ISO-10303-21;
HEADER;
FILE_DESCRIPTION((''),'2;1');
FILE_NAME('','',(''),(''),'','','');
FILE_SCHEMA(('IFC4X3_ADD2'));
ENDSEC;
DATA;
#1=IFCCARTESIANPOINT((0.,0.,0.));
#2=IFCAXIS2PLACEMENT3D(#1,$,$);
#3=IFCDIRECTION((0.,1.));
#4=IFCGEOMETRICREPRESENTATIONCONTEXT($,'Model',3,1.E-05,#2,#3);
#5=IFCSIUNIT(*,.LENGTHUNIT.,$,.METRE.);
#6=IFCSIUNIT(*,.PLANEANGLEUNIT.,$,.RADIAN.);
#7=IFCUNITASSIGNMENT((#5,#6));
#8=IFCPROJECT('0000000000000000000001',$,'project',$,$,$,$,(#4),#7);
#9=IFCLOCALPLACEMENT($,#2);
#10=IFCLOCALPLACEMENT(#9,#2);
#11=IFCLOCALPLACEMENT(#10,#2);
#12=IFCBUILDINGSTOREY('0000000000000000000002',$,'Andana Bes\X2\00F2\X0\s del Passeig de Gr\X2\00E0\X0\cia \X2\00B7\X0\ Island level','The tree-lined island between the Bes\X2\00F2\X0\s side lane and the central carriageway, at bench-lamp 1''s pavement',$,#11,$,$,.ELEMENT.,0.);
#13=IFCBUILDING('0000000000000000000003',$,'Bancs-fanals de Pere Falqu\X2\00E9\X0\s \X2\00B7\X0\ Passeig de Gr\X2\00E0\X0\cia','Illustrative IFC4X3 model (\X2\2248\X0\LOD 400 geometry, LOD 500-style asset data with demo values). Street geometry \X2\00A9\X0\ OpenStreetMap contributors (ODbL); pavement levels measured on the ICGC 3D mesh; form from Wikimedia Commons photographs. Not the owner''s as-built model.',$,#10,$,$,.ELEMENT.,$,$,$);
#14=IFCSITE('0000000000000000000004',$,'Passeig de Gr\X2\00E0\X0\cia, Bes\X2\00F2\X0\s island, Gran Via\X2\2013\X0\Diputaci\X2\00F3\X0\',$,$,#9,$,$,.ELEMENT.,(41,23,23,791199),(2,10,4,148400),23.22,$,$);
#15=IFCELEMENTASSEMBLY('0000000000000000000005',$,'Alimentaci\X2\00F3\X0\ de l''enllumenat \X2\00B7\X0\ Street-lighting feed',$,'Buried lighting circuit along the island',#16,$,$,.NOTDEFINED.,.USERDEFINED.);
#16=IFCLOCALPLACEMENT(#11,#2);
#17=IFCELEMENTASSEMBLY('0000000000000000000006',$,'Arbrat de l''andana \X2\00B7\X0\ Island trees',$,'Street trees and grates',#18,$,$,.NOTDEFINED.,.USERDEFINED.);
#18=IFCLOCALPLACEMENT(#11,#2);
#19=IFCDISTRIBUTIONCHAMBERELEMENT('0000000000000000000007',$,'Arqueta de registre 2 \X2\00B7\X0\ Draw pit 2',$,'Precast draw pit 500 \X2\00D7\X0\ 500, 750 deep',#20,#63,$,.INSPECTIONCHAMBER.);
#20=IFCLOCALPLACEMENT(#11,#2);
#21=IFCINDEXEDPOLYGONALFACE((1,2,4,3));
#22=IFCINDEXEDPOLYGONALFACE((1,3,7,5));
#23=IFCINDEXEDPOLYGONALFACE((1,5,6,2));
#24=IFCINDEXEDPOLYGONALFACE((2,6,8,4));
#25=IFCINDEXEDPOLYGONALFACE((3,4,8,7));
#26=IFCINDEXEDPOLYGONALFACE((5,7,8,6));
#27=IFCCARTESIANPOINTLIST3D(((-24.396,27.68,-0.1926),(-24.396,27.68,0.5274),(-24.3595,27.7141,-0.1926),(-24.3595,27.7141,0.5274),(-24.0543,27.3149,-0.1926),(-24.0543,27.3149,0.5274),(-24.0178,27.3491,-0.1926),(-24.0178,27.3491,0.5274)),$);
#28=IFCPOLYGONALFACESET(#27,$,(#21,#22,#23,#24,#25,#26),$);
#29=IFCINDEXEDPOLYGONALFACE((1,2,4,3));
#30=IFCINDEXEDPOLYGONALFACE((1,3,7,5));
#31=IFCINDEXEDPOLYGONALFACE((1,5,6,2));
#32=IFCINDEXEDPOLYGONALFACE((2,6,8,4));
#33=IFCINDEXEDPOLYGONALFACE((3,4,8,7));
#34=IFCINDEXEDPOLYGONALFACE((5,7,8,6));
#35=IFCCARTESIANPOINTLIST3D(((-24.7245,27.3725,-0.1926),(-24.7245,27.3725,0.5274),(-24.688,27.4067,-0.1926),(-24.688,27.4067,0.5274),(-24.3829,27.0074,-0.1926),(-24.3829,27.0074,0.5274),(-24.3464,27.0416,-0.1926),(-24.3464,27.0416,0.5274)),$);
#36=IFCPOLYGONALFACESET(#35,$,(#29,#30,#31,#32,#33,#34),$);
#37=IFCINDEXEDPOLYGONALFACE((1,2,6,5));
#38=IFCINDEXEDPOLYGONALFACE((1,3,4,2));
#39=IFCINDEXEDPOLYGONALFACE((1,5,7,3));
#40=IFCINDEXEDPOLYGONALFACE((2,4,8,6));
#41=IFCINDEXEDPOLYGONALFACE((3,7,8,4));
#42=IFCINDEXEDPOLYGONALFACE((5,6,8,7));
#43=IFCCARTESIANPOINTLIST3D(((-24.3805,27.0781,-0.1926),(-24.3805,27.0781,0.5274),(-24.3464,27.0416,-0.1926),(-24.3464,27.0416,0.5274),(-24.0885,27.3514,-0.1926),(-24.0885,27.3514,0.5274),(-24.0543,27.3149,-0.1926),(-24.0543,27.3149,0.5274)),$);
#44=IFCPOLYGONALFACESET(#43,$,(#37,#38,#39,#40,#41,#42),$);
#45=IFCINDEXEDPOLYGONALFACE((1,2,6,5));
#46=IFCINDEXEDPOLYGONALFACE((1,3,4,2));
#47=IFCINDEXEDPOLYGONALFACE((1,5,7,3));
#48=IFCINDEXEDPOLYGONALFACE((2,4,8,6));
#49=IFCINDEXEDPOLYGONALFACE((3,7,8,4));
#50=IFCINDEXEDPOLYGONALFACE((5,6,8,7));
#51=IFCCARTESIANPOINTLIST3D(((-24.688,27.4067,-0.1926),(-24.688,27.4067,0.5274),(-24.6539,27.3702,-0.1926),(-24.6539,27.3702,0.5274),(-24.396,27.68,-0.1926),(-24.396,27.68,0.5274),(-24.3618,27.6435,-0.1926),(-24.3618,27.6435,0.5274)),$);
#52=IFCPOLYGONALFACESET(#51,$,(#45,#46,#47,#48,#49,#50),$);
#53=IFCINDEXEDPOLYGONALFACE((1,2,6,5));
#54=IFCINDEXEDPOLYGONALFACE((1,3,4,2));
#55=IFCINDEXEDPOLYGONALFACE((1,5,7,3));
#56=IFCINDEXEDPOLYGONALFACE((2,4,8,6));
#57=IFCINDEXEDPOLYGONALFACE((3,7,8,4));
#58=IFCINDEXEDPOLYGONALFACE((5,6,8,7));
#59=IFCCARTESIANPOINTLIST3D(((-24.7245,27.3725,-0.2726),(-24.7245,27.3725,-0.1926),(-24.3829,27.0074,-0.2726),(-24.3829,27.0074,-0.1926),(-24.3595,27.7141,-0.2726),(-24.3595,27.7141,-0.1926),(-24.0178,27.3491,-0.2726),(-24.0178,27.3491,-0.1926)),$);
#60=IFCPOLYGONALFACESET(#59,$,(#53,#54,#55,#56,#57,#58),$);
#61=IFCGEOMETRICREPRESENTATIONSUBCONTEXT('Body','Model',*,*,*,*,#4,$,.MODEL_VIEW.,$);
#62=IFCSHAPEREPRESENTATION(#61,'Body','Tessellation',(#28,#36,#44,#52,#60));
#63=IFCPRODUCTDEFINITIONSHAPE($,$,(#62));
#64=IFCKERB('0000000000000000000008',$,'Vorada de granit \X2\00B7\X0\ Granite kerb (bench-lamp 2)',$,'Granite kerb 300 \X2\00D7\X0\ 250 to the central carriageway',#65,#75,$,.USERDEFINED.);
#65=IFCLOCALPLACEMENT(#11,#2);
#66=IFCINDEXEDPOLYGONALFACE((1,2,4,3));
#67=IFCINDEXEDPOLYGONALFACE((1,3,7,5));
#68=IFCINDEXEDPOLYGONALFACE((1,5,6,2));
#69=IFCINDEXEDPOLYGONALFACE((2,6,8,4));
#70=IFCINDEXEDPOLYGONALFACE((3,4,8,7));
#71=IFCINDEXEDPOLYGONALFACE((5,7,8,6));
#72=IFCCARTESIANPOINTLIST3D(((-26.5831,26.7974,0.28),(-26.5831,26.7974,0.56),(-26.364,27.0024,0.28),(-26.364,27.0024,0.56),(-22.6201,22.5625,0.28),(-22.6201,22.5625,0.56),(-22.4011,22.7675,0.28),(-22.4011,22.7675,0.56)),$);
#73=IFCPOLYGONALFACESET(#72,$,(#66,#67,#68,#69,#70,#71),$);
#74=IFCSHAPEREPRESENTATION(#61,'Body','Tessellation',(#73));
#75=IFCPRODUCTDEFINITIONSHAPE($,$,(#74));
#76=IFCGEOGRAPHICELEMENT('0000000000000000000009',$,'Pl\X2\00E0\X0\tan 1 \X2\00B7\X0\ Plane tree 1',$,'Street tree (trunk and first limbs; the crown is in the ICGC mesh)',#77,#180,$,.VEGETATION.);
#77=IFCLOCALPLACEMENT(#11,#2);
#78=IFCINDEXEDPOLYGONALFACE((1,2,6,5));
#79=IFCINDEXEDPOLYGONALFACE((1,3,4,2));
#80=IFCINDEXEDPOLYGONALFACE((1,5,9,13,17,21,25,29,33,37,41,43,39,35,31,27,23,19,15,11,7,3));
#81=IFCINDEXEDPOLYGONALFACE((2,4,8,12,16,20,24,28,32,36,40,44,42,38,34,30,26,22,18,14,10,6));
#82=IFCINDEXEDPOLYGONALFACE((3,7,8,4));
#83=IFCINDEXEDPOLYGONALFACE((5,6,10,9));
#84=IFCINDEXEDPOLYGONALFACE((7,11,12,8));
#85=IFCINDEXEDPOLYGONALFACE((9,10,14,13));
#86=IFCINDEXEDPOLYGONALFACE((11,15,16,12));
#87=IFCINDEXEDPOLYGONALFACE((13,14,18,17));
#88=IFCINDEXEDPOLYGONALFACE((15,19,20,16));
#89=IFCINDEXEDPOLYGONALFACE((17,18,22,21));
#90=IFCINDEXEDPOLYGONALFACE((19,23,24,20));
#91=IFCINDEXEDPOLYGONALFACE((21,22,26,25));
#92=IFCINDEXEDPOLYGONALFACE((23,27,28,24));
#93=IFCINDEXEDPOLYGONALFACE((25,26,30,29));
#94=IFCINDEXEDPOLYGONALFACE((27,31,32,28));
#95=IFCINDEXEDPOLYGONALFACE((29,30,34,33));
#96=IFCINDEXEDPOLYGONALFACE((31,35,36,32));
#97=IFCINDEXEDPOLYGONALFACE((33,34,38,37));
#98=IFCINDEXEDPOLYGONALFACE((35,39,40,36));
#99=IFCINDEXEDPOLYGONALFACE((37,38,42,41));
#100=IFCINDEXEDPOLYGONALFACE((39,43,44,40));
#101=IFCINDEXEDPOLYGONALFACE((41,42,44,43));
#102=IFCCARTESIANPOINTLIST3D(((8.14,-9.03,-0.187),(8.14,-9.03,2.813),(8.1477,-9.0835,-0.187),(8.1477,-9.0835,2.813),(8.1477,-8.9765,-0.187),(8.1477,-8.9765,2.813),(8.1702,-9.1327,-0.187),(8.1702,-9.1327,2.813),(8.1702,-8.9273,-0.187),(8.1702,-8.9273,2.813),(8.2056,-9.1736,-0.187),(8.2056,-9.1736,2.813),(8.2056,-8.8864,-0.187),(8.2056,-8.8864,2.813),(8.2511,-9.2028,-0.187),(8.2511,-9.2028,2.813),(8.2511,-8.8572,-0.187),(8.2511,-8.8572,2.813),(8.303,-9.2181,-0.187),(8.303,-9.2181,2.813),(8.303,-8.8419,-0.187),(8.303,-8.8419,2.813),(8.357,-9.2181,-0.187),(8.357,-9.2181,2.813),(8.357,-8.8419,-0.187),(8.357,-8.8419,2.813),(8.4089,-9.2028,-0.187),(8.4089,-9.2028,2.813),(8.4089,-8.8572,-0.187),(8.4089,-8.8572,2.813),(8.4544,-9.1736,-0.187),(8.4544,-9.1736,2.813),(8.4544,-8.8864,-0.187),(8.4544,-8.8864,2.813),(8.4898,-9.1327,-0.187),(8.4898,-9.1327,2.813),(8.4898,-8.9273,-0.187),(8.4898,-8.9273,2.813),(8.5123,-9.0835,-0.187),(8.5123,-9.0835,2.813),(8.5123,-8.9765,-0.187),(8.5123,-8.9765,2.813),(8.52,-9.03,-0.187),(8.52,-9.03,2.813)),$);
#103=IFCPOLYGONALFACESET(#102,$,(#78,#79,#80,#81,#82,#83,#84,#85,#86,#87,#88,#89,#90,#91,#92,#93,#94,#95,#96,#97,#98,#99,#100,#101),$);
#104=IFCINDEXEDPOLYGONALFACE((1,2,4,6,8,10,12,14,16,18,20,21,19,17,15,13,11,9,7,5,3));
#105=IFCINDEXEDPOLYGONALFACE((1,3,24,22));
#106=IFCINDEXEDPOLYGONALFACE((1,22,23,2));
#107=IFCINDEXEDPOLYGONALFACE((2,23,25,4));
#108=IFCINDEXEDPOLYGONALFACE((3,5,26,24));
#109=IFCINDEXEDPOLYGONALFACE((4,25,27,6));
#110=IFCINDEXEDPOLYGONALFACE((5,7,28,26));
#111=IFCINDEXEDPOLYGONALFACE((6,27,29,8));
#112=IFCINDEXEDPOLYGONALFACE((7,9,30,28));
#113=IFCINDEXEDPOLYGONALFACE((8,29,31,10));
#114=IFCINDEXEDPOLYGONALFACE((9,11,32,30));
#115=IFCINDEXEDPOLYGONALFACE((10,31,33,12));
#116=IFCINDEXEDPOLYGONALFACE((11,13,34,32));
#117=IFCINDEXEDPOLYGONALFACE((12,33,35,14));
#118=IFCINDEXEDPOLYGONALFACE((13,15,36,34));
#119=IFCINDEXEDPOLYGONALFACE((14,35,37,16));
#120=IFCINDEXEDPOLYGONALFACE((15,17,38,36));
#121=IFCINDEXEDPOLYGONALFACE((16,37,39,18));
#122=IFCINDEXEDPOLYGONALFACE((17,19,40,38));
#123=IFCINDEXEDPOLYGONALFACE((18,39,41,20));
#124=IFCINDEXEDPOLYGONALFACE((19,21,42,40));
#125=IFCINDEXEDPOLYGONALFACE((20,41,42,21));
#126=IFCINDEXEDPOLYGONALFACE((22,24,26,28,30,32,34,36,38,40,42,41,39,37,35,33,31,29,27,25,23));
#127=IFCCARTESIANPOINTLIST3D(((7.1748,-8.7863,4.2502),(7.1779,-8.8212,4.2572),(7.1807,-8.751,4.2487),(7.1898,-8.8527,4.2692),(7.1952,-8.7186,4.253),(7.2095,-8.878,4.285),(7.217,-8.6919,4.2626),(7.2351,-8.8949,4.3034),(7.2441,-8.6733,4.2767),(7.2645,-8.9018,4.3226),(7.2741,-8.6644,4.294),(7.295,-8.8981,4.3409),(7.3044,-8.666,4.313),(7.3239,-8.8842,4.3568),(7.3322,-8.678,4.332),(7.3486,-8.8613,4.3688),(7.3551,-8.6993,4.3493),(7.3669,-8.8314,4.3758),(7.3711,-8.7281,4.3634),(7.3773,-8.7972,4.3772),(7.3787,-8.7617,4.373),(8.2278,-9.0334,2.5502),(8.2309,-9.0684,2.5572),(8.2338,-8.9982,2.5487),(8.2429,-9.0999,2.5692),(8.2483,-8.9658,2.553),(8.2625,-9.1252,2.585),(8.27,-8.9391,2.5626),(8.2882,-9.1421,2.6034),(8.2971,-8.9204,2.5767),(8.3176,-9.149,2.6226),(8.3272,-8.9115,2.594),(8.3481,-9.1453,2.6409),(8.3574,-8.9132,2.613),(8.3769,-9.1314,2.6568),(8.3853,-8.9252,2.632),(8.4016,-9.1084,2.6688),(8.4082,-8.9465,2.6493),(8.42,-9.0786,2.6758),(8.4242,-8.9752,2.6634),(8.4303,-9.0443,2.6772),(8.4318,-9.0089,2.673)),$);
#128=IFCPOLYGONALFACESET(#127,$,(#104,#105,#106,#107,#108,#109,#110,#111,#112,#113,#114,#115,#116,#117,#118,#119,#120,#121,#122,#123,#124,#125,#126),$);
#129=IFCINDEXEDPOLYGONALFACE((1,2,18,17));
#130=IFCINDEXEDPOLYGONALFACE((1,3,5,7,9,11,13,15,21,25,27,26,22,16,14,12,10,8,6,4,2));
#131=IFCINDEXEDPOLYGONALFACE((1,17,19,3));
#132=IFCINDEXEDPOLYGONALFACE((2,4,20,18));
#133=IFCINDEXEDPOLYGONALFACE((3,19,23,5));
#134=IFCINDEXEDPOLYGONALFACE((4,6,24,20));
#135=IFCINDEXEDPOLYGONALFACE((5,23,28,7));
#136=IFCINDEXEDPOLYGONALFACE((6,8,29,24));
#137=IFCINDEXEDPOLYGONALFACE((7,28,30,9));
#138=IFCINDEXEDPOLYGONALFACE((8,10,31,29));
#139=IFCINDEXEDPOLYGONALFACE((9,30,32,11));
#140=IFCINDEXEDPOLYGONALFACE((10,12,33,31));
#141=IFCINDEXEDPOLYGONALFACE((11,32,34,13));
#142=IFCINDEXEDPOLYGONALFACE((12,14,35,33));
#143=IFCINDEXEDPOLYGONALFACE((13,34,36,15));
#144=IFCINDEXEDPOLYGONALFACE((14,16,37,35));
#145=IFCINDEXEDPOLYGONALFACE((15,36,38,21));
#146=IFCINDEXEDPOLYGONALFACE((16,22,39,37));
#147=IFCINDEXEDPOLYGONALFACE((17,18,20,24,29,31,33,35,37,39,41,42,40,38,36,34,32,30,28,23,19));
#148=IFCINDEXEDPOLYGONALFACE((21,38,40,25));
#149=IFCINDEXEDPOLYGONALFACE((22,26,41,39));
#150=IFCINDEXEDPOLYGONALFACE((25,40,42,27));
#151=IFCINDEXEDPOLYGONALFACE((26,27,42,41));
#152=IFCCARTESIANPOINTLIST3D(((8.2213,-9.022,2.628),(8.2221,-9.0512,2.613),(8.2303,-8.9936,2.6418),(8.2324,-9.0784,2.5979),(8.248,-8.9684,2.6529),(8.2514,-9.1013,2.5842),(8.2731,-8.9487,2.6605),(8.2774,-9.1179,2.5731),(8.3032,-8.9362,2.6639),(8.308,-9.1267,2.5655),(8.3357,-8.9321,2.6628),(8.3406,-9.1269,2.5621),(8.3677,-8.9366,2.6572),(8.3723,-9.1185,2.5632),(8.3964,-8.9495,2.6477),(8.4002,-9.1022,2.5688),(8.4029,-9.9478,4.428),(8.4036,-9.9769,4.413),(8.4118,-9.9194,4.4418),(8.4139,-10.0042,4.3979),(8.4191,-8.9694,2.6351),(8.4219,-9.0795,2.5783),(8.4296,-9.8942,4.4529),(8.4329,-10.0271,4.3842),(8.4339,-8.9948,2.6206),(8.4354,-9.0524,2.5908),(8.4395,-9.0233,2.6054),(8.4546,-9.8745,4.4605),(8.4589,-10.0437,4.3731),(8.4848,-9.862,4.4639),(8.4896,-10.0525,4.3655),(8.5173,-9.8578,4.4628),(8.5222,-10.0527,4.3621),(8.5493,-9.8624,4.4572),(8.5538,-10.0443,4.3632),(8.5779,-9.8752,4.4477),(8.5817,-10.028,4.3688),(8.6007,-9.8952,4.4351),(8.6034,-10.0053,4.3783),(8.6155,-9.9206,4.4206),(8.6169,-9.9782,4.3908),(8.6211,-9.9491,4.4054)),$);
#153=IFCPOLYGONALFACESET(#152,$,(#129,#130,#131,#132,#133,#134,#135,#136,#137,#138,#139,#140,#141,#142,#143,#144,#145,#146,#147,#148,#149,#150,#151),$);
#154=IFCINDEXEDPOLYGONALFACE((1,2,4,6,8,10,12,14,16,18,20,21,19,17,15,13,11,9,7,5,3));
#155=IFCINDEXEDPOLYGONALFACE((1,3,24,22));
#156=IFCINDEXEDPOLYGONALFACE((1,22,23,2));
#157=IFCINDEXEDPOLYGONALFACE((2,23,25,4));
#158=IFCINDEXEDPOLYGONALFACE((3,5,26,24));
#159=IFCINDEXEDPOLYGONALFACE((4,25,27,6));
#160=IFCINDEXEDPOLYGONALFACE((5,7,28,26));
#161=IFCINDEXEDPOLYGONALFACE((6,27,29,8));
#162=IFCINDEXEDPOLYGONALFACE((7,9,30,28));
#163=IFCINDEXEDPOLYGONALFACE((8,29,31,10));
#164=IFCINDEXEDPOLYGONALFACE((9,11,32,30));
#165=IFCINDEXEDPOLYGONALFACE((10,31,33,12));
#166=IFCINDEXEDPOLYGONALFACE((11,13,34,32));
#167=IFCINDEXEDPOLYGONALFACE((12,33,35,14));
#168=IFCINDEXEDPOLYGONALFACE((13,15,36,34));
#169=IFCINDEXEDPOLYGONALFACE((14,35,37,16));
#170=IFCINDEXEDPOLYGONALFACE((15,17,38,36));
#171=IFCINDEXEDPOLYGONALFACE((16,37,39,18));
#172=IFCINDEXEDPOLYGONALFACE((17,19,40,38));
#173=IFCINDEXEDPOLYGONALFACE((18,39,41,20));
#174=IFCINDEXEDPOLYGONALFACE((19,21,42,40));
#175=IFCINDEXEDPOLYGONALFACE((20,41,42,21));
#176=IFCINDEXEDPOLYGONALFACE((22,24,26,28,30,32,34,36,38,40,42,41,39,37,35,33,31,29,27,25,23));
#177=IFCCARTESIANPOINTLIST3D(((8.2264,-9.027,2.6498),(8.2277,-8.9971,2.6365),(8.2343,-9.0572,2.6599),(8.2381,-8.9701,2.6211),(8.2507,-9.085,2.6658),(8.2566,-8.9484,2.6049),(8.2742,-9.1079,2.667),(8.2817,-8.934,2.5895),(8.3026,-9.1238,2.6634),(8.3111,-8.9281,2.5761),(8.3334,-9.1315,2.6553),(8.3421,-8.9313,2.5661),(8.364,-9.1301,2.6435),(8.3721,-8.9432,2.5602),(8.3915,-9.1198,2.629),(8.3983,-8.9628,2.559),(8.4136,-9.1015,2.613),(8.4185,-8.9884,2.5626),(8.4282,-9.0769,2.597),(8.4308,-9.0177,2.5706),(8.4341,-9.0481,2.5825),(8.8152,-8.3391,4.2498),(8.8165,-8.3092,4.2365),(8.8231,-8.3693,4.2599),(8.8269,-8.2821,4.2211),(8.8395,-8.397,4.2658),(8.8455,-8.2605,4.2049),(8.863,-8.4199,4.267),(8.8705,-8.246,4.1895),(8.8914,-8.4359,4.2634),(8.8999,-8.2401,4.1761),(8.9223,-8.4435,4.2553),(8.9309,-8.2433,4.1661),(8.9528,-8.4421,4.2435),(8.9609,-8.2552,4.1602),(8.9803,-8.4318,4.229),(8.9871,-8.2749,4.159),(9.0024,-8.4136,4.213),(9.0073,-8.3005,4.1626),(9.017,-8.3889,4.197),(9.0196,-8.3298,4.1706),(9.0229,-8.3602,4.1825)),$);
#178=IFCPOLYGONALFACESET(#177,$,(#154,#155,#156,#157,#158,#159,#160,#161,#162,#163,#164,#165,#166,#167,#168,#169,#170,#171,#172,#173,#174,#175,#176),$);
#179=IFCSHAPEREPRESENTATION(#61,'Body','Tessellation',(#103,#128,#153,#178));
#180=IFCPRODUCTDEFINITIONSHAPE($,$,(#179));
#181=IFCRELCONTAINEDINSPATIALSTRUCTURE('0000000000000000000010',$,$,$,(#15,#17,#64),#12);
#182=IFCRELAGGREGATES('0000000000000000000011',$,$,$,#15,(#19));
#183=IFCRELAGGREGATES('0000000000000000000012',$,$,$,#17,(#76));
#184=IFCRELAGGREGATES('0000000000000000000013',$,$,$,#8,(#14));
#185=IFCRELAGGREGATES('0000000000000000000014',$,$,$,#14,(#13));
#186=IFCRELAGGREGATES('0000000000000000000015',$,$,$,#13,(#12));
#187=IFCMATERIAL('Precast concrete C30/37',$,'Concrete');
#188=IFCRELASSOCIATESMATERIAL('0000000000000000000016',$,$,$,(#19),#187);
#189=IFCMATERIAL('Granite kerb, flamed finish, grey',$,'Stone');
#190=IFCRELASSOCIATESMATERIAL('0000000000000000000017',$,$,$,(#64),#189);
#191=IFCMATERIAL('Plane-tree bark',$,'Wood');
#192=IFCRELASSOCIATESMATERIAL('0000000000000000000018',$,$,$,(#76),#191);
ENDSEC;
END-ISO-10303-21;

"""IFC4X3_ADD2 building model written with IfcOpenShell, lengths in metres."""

from ifc_helpers import new_model, si_unit, direction, frame, frame_2d, origin, origin_2d_with_axis, place, context, subcontext, project, spatial, rectangle, circle, extrude, material, element, aggregate, save


model = new_model("IFC4X3_ADD2")

# Units and contexts
model_context = context("Model", 3, precision=1e-05, world=origin(), true_north=direction((0.0, 1.0)))
body_context = subcontext(model_context, "Body", "Model", "MODEL_VIEW")
ifc_project = project(units=[si_unit("LENGTHUNIT", "METRE"), si_unit("PLANEANGLEUNIT", "RADIAN")], contexts=[model_context])

# Site, building, storey
site_placement = place(None, origin())
site = spatial("IfcSite", under=ifc_project, at=site_placement, Name="Passeig de Gràcia, Besòs island, Gran Via–Diputació", CompositionType="ELEMENT", RefLatitude=(41, 23, 23, 791199), RefLongitude=(2, 10, 4, 148400), RefElevation=23.22)
building_placement = place(site_placement, origin())
building = spatial("IfcBuilding", under=site, at=building_placement, Name="Bancs-fanals de Pere Falqués · Passeig de Gràcia", Description="Illustrative IFC4X3 model (≈LOD 400 geometry, LOD 500-style asset data with demo values). Street geometry © OpenStreetMap contributors (ODbL); pavement levels measured on the ICGC 3D mesh; form from Wikimedia Commons photographs. Not the owner's as-built model.", CompositionType="ELEMENT")
storey_placement = place(building_placement, origin())
storey = spatial("IfcBuildingStorey", under=building, at=storey_placement, Name="Andana Besòs del Passeig de Gràcia · Island level", Description="The tree-lined island between the Besòs side lane and the central carriageway, at bench-lamp 1's pavement", CompositionType="ELEMENT", Elevation=0.0)

# Element assemblies
assembly_1_placement = place(building_placement, origin())
assembly_1 = element("IfcElementAssembly", 1, at=assembly_1_placement, inside=storey, Name="Alimentació de l'enllumenat · Street-lighting feed", ObjectType="Buried lighting circuit along the island", AssemblyPlace="NOTDEFINED", PredefinedType="USERDEFINED")
assembly_2_placement = place(building_placement, origin())
assembly_2 = element("IfcElementAssembly", 2, at=assembly_2_placement, inside=storey, Name="Arbrat de l'andana · Island trees", ObjectType="Street trees and grates", AssemblyPlace="NOTDEFINED", PredefinedType="USERDEFINED")

# Distribution chamber element
ifc_material_1 = material(Name="Precast concrete C30/37", Category="Concrete")
distribution_chamber_element_1_placement = place(building_placement, origin())
distribution_chamber_element_1 = element("IfcDistributionChamberElement", 3, at=distribution_chamber_element_1_placement, material=ifc_material_1, Name="Arqueta de registre 2 · Draw pit 2", ObjectType="Precast draw pit 500 × 500, 750 deep", PredefinedType="INSPECTIONCHAMBER", context=body_context, shape_type="SweptSolid", body=[
    extrude(rectangle(XDim=0.5, YDim=0.05, at=frame_2d((0.0, 0.0), x_axis=(-0.683274, 0.730162))), frame((-24.2069, 27.5145, -0.1926)), (0.0, 0.0, 1.0), 0.72),
    extrude(rectangle(XDim=0.5, YDim=0.05, at=frame_2d((0.0, 0.0), x_axis=(-0.683274, 0.730162))), frame((-24.5355, 27.2071, -0.1926)), (0.0, 0.0, 1.0), 0.72),
    extrude(rectangle(XDim=0.05, YDim=0.4, at=frame_2d((0.0, 0.0), x_axis=(-0.683274, 0.730162))), frame((-24.2174, 27.1965, -0.1926)), (0.0, 0.0, 1.0), 0.72),
    extrude(rectangle(XDim=0.05, YDim=0.4, at=frame_2d((0.0, 0.0), x_axis=(-0.683274, 0.730162))), frame((-24.5249, 27.5251, -0.1926)), (0.0, 0.0, 1.0), 0.72),
    extrude(rectangle(XDim=0.5, YDim=0.5, at=frame_2d((0.0, 0.0), x_axis=(-0.683274, 0.730162))), frame((-24.3712, 27.3608, -0.2726)), (0.0, 0.0, 1.0), 0.08),
])
aggregate(assembly_1, [distribution_chamber_element_1])

# Kerb
ifc_material_2 = material(Name="Granite kerb, flamed finish, grey", Category="Stone")
kerb_placement = place(building_placement, origin())
element("IfcKerb", 4, at=kerb_placement, inside=storey, material=ifc_material_2, Name="Vorada de granit · Granite kerb (bench-lamp 2)", ObjectType="Granite kerb 300 × 250 to the central carriageway", PredefinedType="USERDEFINED", context=body_context, shape_type="SweptSolid", body=[
    extrude(rectangle(XDim=5.8, YDim=0.3, at=frame_2d((0.0, 0.0), x_axis=(-0.683274, 0.730162))), frame((-24.4921, 24.7824, 0.28)), (0.0, 0.0, 1.0), 0.28),
])

# Geographic element
ifc_material_3 = material(Name="Plane-tree bark", Category="Wood")
geographic_element_1_placement = place(building_placement, origin())
geographic_element_1 = element("IfcGeographicElement", 5, at=geographic_element_1_placement, material=ifc_material_3, Name="Plàtan 1 · Plane tree 1", ObjectType="Street tree (trunk and first limbs; the crown is in the ICGC mesh)", PredefinedType="VEGETATION", context=body_context, shape_type="SweptSolid", body=[
    extrude(circle(Radius=0.19, at=origin_2d_with_axis()), frame((8.33, -9.03, -0.187)), (0.0, 0.0, 1.0), 3.0),
    extrude(circle(Radius=0.12, at=origin_2d_with_axis()), frame((8.33, -9.03, 2.613), z_axis=(-0.522617, 0.122674, 0.843696), x_axis=(0.22852, 0.973539, 0.0)), (0.0, 0.0, 1.0), 2.0149),
    extrude(circle(Radius=0.11, at=origin_2d_with_axis()), frame((8.33, -9.03, 2.613), z_axis=(0.089329, -0.45554, 0.885722), x_axis=(-0.981311, -0.19243, 0.0)), (0.0, 0.0, 1.0), 2.0322),
    extrude(circle(Radius=0.11, at=origin_2d_with_axis()), frame((8.33, -9.03, 2.613), z_axis=(0.320275, 0.374202, 0.870285), x_axis=(0.759728, -0.650241, 0.0)), (0.0, 0.0, 1.0), 1.8385),
])
aggregate(assembly_2, [geographic_element_1])

save(model, "model.ifc")
